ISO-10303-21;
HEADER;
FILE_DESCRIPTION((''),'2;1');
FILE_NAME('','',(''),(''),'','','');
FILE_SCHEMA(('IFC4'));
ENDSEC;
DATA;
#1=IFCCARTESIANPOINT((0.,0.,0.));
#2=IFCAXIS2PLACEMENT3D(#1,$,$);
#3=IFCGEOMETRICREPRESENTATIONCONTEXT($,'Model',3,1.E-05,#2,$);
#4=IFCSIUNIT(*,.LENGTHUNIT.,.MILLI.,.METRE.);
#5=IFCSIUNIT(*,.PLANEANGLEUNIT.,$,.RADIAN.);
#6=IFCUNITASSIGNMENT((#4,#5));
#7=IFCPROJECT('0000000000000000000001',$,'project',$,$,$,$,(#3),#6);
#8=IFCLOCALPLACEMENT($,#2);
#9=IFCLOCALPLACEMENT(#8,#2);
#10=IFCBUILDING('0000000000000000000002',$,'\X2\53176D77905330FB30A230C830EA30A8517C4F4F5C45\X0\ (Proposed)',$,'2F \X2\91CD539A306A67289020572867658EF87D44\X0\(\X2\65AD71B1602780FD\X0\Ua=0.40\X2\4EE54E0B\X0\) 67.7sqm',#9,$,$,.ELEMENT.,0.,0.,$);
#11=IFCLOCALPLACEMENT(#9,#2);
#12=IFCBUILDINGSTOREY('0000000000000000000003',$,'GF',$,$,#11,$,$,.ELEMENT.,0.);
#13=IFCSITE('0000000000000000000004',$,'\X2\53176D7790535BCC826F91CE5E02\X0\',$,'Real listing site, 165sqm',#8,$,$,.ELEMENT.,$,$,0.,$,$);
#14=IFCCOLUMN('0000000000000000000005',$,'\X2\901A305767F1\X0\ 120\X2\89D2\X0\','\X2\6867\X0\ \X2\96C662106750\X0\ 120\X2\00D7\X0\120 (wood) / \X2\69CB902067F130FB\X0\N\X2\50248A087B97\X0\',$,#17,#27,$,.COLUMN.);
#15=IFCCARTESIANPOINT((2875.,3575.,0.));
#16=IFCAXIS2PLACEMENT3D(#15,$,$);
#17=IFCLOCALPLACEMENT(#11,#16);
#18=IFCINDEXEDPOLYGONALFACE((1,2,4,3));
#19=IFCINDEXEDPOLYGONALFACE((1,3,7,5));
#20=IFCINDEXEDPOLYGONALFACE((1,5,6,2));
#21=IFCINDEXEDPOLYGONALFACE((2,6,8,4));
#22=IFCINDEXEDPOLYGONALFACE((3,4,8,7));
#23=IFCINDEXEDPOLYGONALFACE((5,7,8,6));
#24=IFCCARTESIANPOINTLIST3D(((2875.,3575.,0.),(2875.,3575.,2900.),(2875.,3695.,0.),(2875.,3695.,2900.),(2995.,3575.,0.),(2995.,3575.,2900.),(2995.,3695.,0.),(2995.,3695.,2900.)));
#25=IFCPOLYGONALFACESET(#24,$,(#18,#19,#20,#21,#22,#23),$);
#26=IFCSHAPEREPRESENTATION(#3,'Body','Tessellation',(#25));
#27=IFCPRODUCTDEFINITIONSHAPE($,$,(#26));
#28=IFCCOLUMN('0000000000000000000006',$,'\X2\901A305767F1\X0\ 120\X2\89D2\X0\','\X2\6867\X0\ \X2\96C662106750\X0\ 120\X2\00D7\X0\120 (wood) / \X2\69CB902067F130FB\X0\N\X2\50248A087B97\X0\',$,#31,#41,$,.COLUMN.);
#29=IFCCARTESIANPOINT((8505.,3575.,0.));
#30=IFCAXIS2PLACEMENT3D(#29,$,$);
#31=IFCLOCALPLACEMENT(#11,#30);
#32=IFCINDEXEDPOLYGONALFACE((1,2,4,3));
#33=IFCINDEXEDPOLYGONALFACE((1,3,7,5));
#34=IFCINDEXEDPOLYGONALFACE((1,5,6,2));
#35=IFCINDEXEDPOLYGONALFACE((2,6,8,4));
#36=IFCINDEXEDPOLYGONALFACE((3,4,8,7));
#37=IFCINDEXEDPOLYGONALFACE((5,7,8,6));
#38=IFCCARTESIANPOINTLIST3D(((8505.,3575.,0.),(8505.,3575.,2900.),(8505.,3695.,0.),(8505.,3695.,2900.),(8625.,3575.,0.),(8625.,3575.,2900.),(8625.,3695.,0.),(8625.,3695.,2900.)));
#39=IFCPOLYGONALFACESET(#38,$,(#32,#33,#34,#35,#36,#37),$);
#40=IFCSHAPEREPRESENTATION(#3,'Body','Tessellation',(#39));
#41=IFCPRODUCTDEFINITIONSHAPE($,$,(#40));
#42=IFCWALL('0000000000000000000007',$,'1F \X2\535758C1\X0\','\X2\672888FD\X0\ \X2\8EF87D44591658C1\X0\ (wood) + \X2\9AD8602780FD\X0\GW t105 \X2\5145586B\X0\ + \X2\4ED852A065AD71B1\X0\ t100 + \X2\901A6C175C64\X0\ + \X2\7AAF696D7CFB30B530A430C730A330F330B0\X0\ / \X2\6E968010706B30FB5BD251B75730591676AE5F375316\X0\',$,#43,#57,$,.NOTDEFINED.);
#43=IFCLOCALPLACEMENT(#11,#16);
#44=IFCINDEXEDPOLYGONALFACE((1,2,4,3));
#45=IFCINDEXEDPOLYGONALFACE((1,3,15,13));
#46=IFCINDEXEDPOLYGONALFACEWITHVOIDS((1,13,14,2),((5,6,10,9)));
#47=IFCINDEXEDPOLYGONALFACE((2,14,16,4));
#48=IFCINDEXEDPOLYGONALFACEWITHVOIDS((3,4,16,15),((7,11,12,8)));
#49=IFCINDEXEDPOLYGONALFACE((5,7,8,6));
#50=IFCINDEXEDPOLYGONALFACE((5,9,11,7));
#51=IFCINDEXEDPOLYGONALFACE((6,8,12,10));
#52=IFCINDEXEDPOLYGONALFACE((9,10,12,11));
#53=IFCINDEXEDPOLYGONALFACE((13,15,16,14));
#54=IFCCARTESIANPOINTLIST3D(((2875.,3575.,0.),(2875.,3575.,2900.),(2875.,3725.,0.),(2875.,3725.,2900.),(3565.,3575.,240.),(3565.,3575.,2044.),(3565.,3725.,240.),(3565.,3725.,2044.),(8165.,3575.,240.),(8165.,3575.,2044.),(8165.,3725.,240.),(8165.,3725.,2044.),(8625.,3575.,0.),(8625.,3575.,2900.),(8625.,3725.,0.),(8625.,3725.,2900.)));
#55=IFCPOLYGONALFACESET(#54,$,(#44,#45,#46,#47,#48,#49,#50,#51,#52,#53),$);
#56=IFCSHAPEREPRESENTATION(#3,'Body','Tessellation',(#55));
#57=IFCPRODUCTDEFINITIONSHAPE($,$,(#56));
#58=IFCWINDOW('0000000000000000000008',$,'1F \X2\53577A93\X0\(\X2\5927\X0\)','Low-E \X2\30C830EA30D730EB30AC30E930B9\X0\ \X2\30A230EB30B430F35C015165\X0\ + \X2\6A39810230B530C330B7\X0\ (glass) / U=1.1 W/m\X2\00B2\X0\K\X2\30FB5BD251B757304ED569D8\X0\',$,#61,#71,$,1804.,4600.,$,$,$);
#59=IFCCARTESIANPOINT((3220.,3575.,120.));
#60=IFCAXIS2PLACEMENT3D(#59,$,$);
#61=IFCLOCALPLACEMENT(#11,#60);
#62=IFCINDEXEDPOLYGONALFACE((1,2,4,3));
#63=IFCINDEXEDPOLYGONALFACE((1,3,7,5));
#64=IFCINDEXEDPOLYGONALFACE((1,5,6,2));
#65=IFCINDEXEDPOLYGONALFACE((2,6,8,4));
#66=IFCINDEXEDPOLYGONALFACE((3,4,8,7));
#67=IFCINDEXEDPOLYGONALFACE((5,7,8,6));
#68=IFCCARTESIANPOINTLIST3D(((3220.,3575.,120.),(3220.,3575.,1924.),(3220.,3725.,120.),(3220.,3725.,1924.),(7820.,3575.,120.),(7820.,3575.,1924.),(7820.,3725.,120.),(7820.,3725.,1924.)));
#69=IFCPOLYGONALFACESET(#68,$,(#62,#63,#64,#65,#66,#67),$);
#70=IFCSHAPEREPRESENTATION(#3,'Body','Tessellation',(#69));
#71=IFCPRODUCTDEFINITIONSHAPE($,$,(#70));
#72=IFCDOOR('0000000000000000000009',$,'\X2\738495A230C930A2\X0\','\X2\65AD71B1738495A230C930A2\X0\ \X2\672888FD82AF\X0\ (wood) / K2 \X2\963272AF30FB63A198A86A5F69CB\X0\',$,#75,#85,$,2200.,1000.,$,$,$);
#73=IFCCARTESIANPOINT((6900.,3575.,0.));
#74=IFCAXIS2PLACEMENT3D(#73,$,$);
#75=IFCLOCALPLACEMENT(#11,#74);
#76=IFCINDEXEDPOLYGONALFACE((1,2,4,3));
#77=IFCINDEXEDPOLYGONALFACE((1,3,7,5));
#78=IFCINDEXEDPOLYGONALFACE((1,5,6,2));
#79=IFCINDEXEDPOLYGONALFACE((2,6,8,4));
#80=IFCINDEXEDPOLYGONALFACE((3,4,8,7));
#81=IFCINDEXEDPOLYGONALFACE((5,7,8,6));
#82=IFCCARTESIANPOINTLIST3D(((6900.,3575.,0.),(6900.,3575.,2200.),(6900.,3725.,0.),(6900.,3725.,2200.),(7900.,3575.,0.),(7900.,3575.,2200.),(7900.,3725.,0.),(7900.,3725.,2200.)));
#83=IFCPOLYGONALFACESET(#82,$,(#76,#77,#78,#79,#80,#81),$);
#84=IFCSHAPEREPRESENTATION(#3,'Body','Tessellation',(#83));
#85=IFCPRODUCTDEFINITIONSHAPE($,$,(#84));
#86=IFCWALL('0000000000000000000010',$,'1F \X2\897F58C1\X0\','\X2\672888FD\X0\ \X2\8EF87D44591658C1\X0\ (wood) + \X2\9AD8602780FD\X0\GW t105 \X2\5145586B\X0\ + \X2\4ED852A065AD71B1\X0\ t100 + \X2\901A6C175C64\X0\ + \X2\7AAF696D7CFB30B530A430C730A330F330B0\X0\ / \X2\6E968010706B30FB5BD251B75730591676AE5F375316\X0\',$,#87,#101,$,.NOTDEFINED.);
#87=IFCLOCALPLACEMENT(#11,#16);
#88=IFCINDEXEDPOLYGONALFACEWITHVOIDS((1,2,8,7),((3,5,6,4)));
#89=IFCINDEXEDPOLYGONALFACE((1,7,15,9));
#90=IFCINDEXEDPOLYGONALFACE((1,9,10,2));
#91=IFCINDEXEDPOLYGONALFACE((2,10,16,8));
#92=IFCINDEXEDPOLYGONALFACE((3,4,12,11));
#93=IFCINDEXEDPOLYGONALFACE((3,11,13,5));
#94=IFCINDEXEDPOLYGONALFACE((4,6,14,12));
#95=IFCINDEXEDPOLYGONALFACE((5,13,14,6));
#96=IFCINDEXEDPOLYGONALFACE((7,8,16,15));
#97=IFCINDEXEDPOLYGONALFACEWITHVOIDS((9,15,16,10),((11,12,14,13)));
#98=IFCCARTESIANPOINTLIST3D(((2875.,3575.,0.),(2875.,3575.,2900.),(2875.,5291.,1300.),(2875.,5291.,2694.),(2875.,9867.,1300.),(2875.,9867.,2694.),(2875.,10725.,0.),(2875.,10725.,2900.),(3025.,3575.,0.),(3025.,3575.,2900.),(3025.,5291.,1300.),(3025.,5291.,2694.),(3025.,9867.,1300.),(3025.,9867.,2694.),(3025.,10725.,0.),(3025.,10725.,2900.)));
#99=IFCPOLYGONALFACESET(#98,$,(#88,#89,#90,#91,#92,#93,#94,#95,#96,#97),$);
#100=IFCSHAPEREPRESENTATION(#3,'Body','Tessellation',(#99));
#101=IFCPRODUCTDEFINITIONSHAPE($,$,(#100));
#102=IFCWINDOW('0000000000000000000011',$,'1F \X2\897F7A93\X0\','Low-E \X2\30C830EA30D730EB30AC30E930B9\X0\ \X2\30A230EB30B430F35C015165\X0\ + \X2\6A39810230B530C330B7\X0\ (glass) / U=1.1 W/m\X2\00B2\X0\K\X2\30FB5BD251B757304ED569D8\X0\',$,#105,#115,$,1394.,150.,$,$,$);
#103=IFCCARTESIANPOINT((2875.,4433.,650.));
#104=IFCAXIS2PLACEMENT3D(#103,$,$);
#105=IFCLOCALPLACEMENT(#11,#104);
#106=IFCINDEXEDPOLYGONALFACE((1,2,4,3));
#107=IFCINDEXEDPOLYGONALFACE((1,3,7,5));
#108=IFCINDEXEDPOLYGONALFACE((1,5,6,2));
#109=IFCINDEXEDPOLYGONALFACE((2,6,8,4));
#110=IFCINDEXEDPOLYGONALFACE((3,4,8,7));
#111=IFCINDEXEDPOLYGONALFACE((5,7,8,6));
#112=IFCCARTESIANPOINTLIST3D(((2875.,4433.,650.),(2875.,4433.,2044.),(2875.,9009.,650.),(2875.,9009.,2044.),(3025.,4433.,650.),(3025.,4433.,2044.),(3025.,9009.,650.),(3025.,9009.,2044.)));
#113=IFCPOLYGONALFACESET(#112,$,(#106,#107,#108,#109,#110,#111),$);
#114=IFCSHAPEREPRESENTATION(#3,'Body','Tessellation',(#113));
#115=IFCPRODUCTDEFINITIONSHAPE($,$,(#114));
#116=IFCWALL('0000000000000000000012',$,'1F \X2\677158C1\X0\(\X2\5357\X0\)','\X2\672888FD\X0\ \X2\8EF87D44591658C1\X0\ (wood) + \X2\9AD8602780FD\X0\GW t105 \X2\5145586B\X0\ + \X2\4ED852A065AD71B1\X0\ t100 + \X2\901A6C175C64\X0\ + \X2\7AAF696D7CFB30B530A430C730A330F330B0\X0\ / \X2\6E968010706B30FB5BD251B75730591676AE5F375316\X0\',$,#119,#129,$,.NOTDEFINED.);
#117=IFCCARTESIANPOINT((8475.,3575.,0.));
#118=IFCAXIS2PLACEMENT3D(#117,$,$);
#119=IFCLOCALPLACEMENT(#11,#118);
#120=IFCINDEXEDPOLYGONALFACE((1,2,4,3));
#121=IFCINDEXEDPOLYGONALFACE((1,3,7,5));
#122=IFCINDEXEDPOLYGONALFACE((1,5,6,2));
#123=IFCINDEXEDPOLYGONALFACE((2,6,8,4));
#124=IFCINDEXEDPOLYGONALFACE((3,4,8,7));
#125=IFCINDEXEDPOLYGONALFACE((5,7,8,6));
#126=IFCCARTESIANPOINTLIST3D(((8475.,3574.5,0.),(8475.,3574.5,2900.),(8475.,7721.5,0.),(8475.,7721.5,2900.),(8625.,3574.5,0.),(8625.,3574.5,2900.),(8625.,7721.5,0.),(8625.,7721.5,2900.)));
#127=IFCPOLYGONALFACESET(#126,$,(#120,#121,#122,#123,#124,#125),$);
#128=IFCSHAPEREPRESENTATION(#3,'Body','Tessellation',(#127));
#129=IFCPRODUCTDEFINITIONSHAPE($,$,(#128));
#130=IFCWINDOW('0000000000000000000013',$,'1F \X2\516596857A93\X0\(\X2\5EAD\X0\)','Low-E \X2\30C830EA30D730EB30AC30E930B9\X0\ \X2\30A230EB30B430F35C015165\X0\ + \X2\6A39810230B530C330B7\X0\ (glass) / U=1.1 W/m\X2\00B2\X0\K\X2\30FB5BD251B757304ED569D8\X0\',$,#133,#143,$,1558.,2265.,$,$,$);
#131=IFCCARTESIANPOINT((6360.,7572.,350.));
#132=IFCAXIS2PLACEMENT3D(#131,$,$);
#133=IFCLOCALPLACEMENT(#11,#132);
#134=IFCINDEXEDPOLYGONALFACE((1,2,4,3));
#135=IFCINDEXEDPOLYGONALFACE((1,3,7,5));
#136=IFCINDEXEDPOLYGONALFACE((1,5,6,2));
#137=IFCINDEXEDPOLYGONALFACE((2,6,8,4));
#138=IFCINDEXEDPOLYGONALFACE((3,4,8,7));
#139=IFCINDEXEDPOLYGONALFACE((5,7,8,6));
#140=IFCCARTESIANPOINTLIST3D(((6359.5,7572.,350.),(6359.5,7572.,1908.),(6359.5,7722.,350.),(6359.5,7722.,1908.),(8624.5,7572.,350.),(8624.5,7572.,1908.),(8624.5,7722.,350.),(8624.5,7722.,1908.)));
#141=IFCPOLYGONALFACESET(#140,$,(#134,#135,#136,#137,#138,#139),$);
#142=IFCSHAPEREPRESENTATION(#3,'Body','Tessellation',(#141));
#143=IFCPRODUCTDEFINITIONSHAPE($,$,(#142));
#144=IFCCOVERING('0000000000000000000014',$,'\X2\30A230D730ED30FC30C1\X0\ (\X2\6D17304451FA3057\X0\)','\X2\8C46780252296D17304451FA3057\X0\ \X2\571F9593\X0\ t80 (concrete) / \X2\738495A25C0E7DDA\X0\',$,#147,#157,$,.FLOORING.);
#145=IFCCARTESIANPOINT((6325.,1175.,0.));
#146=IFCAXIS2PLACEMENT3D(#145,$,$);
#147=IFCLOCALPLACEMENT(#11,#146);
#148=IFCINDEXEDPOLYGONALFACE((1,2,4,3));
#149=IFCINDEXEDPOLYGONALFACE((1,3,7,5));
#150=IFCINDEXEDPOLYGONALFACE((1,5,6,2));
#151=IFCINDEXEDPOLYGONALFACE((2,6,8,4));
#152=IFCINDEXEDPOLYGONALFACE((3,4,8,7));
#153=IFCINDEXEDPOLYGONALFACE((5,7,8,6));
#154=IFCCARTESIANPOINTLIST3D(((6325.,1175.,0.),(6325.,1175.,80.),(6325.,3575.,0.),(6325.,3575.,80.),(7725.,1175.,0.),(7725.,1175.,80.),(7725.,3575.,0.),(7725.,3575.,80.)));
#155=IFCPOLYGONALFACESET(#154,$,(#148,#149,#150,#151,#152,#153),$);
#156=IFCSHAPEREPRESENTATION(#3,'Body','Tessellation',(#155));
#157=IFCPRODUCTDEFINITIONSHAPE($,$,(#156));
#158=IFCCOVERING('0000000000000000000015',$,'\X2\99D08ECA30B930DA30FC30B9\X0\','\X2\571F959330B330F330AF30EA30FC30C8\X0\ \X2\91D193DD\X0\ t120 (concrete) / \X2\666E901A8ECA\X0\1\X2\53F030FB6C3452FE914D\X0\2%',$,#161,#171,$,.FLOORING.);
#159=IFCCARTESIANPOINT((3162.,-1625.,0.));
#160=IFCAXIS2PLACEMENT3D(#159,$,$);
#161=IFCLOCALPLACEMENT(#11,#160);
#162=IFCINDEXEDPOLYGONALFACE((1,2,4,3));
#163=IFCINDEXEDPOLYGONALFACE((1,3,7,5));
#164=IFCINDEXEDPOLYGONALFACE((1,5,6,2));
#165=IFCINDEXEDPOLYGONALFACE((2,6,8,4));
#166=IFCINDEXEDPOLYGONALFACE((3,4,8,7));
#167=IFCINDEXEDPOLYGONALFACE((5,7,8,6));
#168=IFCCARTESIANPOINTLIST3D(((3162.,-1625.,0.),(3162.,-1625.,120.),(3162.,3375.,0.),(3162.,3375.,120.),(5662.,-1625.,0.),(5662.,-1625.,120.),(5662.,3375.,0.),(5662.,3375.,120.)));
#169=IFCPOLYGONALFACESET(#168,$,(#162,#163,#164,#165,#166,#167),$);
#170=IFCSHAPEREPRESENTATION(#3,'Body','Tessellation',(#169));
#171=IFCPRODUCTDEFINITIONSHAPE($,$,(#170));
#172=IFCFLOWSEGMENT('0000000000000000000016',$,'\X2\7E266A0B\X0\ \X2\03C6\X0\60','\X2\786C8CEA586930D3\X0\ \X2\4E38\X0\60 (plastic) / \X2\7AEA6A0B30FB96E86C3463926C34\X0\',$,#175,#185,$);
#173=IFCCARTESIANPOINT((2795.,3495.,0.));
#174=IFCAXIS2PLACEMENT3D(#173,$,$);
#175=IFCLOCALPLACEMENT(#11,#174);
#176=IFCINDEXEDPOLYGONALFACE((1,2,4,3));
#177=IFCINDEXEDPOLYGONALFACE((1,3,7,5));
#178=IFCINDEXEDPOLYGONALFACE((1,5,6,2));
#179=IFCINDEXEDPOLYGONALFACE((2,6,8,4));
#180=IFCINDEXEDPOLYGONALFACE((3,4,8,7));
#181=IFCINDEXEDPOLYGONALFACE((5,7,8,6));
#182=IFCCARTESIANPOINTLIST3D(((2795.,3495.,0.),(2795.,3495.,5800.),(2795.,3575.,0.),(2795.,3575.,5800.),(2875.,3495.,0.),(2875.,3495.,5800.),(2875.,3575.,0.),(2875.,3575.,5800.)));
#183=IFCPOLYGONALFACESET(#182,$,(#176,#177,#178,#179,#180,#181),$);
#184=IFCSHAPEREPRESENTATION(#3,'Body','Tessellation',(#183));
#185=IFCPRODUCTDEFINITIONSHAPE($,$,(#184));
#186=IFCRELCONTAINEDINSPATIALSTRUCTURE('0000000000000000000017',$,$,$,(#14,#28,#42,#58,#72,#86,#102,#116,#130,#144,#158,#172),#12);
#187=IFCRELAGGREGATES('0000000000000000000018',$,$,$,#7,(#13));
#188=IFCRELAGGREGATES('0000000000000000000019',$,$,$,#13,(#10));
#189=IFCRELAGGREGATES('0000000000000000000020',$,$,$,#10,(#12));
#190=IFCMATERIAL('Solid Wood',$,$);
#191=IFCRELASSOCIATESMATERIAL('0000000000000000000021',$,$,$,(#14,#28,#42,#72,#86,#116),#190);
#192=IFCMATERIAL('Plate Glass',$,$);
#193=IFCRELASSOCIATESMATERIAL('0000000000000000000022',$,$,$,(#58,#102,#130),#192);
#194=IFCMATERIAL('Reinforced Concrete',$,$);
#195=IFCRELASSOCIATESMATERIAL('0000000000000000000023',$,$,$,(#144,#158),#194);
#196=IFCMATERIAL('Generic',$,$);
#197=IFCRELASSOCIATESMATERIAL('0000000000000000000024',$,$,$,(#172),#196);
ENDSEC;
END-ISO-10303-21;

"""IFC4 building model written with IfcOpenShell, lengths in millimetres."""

from ifc_helpers import new_model, si_unit, frame, frame_2d, origin, place, context, project, spatial, rectangle, extrude, material, element, fill, save


model = new_model("IFC4")

# Units and contexts
model_context = context("Model", 3, precision=1e-05, world=origin())
ifc_project = project(units=[si_unit("LENGTHUNIT", "METRE", prefix="MILLI"), si_unit("PLANEANGLEUNIT", "RADIAN")], contexts=[model_context])

# Site, building, storey
site_placement = place(None, origin())
site = spatial("IfcSite", under=ifc_project, at=site_placement, Name="北海道富良野市", ObjectType="Real listing site, 165sqm", CompositionType="ELEMENT", RefElevation=0.0)
building_placement = place(site_placement, origin())
building = spatial("IfcBuilding", under=site, at=building_placement, Name="北海道・アトリエ兼住居 (Proposed)", ObjectType="2F 重厚な木造在来軸組(断熱性能Ua=0.40以下) 67.7sqm", CompositionType="ELEMENT", ElevationOfRefHeight=0.0, ElevationOfTerrain=0.0)
storey_placement = place(building_placement, origin())
storey = spatial("IfcBuildingStorey", under=building, at=storey_placement, Name="GF", CompositionType="ELEMENT", Elevation=0.0)

# Columns
ifc_material_1 = material(Name="Solid Wood")
column_1_placement = place(storey_placement, frame((2875.0, 3575.0, 0.0)))
element("IfcColumn", 1, at=column_1_placement, inside=storey, material=ifc_material_1, Name="通し柱 120角", Description="桧 集成材 120×120 (wood) / 構造柱・N値計算", PredefinedType="COLUMN", context=model_context, shape_type="SweptSolid", body=[
    extrude(rectangle(XDim=120.0, YDim=120.0, at=frame_2d((60.0, 60.0))), frame((2875.0, 3575.0, 0.0)), (0.0, 0.0, 1.0), 2900.0),
])
column_2_placement = place(storey_placement, frame((8505.0, 3575.0, 0.0)))
element("IfcColumn", 2, at=column_2_placement, inside=storey, material=ifc_material_1, Name="通し柱 120角", Description="桧 集成材 120×120 (wood) / 構造柱・N値計算", PredefinedType="COLUMN", context=model_context, shape_type="SweptSolid", body=[
    extrude(rectangle(XDim=120.0, YDim=120.0, at=frame_2d((60.0, 60.0))), frame((8505.0, 3575.0, 0.0)), (0.0, 0.0, 1.0), 2900.0),
])

# Shared definitions
ifc_material_2 = material(Name="Reinforced Concrete")

# Wall, openings, window, door
wall_1_placement = place(storey_placement, frame((2875.0, 3575.0, 0.0)))
wall_1 = element("IfcWall", 3, at=wall_1_placement, inside=storey, material=ifc_material_1, Name="1F 南壁", Description="木製 軸組外壁 (wood) + 高性能GW t105 充填 + 付加断熱 t100 + 通気層 + 窯業系サイディング / 準耐火・寒冷地外皮強化", PredefinedType="NOTDEFINED", context=model_context, shape_type="SweptSolid", body=[
    extrude(rectangle(XDim=5750.0, YDim=150.0, at=frame_2d((2875.0, 75.0))), frame((2875.0, 3575.0, 0.0)), (0.0, 0.0, 1.0), 2900.0),
])
opening_1_placement = place(storey_placement, frame((3220.0, 3575.0, 120.0)))
opening_1 = element("IfcOpeningElement", 4, at=opening_1_placement, cuts=wall_1, PredefinedType="NOTDEFINED", context=model_context, shape_type="SweptSolid", body=[
    extrude(rectangle(XDim=4600.0, YDim=150.0, at=frame_2d((2300.0, 75.0))), frame((3220.0, 3575.0, 120.0)), (0.0, 0.0, 1.0), 1804.0),
])
opening_2_placement = place(storey_placement, frame((6900.0, 3575.0, 0.0)))
opening_2 = element("IfcOpeningElement", 5, at=opening_2_placement, cuts=wall_1, PredefinedType="NOTDEFINED", context=model_context, shape_type="SweptSolid", body=[
    extrude(rectangle(XDim=1000.0, YDim=150.0, at=frame_2d((500.0, 75.0))), frame((6900.0, 3575.0, 0.0)), (0.0, 0.0, 1.0), 2200.0),
])
ifc_material_3 = material(Name="Plate Glass")
window_1_placement = place(storey_placement, frame((3220.0, 3575.0, 120.0)))
window_1 = element("IfcWindow", 6, at=window_1_placement, inside=storey, material=ifc_material_3, Name="1F 南窓(大)", Description="Low-E トリプルガラス アルゴン封入 + 樹脂サッシ (glass) / U=1.1 W/m²K・寒冷地仕様", OverallHeight=1804.0, OverallWidth=4600.0, context=model_context, shape_type="SweptSolid", body=[
    extrude(rectangle(XDim=4600.0, YDim=150.0, at=frame_2d((2300.0, 75.0))), frame((3220.0, 3575.0, 120.0)), (0.0, 0.0, 1.0), 1804.0),
])
fill(opening_1, window_1)
door_1_placement = place(storey_placement, frame((6900.0, 3575.0, 0.0)))
door_1 = element("IfcDoor", 7, at=door_1_placement, inside=storey, material=ifc_material_1, Name="玄関ドア", Description="断熱玄関ドア 木製芯 (wood) / K2 防犯・採風機構", OverallHeight=2200.0, OverallWidth=1000.0, context=model_context, shape_type="SweptSolid", body=[
    extrude(rectangle(XDim=1000.0, YDim=150.0, at=frame_2d((500.0, 75.0))), frame((6900.0, 3575.0, 0.0)), (0.0, 0.0, 1.0), 2200.0),
])
fill(opening_2, door_1)

# Walls, openings, windows
wall_2_placement = place(storey_placement, frame((2875.0, 3575.0, 0.0)))
wall_2 = element("IfcWall", 8, at=wall_2_placement, inside=storey, material=ifc_material_1, Name="1F 西壁", Description="木製 軸組外壁 (wood) + 高性能GW t105 充填 + 付加断熱 t100 + 通気層 + 窯業系サイディング / 準耐火・寒冷地外皮強化", PredefinedType="NOTDEFINED", context=model_context, shape_type="SweptSolid", body=[
    extrude(rectangle(XDim=150.0, YDim=7150.0, at=frame_2d((75.0, 3575.0))), frame((2875.0, 3575.0, 0.0)), (0.0, 0.0, 1.0), 2900.0),
])
opening_3_placement = place(storey_placement, frame((2875.0, 4433.0, 650.0)))
opening_3 = element("IfcOpeningElement", 9, at=opening_3_placement, cuts=wall_2, PredefinedType="NOTDEFINED", context=model_context, shape_type="SweptSolid", body=[
    extrude(rectangle(XDim=150.0, YDim=4576.0, at=frame_2d((75.0, 2288.0))), frame((2875.0, 4433.0, 650.0)), (0.0, 0.0, 1.0), 1394.0),
])
window_2_placement = place(storey_placement, frame((2875.0, 4433.0, 650.0)))
window_2 = element("IfcWindow", 10, at=window_2_placement, inside=storey, material=ifc_material_3, Name="1F 西窓", Description="Low-E トリプルガラス アルゴン封入 + 樹脂サッシ (glass) / U=1.1 W/m²K・寒冷地仕様", OverallHeight=1394.0, OverallWidth=150.0, context=model_context, shape_type="SweptSolid", body=[
    extrude(rectangle(XDim=150.0, YDim=4576.0, at=frame_2d((75.0, 2288.0))), frame((2875.0, 4433.0, 650.0)), (0.0, 0.0, 1.0), 1394.0),
])
fill(opening_3, window_2)
wall_3_placement = place(storey_placement, frame((8475.0, 3575.0, 0.0)))
wall_3 = element("IfcWall", 11, at=wall_3_placement, inside=storey, material=ifc_material_1, Name="1F 東壁(南)", Description="木製 軸組外壁 (wood) + 高性能GW t105 充填 + 付加断熱 t100 + 通気層 + 窯業系サイディング / 準耐火・寒冷地外皮強化", PredefinedType="NOTDEFINED", context=model_context, shape_type="SweptSolid", body=[
    extrude(rectangle(XDim=150.0, YDim=4147.0, at=frame_2d((75.0, 2073.0))), frame((8475.0, 3575.0, 0.0)), (0.0, 0.0, 1.0), 2900.0),
])
opening_4_placement = place(storey_placement, frame((6360.0, 7572.0, 350.0)))
opening_4 = element("IfcOpeningElement", 12, at=opening_4_placement, cuts=wall_3, PredefinedType="NOTDEFINED", context=model_context, shape_type="SweptSolid", body=[
    extrude(rectangle(XDim=2265.0, YDim=150.0, at=frame_2d((1132.0, 75.0))), frame((6360.0, 7572.0, 350.0)), (0.0, 0.0, 1.0), 1558.0),
])
window_3_placement = place(storey_placement, frame((6360.0, 7572.0, 350.0)))
window_3 = element("IfcWindow", 13, at=window_3_placement, inside=storey, material=ifc_material_3, Name="1F 入隅窓(庭)", Description="Low-E トリプルガラス アルゴン封入 + 樹脂サッシ (glass) / U=1.1 W/m²K・寒冷地仕様", OverallHeight=1558.0, OverallWidth=2265.0, context=model_context, shape_type="SweptSolid", body=[
    extrude(rectangle(XDim=2265.0, YDim=150.0, at=frame_2d((1132.0, 75.0))), frame((6360.0, 7572.0, 350.0)), (0.0, 0.0, 1.0), 1558.0),
])
fill(opening_4, window_3)

# Coverings
covering_1_placement = place(storey_placement, frame((6325.0, 1175.0, 0.0)))
element("IfcCovering", 14, at=covering_1_placement, inside=storey, material=ifc_material_2, Name="アプローチ (洗い出し)", Description="豆砂利洗い出し 土間 t80 (concrete) / 玄関導線", PredefinedType="FLOORING", context=model_context, shape_type="SweptSolid", body=[
    extrude(rectangle(XDim=1400.0, YDim=2400.0, at=frame_2d((700.0, 1200.0))), frame((6325.0, 1175.0, 0.0)), (0.0, 0.0, 1.0), 80.0),
])
covering_2_placement = place(storey_placement, frame((3162.0, -1625.0, 0.0)))
element("IfcCovering", 15, at=covering_2_placement, inside=storey, material=ifc_material_2, Name="駐車スペース", Description="土間コンクリート 金鏝 t120 (concrete) / 普通車1台・水勾配2%", PredefinedType="FLOORING", context=model_context, shape_type="SweptSolid", body=[
    extrude(rectangle(XDim=2500.0, YDim=5000.0, at=frame_2d((1250.0, 2500.0))), frame((3162.0, -1625.0, 0.0)), (0.0, 0.0, 1.0), 120.0),
])

# Flow segment
ifc_material_4 = material(Name="Generic")
flow_segment_1_placement = place(storey_placement, frame((2795.0, 3495.0, 0.0)))
element("IfcFlowSegment", 16, at=flow_segment_1_placement, inside=storey, material=ifc_material_4, Name="縦樋 φ60", Description="硬質塩ビ 丸60 (plastic) / 竪樋・雨水排水", context=model_context, shape_type="SweptSolid", body=[
    extrude(rectangle(XDim=80.0, YDim=80.0, at=frame_2d((40.0, 40.0))), frame((2795.0, 3495.0, 0.0)), (0.0, 0.0, 1.0), 5800.0),
])

save(model, "model.ifc")
